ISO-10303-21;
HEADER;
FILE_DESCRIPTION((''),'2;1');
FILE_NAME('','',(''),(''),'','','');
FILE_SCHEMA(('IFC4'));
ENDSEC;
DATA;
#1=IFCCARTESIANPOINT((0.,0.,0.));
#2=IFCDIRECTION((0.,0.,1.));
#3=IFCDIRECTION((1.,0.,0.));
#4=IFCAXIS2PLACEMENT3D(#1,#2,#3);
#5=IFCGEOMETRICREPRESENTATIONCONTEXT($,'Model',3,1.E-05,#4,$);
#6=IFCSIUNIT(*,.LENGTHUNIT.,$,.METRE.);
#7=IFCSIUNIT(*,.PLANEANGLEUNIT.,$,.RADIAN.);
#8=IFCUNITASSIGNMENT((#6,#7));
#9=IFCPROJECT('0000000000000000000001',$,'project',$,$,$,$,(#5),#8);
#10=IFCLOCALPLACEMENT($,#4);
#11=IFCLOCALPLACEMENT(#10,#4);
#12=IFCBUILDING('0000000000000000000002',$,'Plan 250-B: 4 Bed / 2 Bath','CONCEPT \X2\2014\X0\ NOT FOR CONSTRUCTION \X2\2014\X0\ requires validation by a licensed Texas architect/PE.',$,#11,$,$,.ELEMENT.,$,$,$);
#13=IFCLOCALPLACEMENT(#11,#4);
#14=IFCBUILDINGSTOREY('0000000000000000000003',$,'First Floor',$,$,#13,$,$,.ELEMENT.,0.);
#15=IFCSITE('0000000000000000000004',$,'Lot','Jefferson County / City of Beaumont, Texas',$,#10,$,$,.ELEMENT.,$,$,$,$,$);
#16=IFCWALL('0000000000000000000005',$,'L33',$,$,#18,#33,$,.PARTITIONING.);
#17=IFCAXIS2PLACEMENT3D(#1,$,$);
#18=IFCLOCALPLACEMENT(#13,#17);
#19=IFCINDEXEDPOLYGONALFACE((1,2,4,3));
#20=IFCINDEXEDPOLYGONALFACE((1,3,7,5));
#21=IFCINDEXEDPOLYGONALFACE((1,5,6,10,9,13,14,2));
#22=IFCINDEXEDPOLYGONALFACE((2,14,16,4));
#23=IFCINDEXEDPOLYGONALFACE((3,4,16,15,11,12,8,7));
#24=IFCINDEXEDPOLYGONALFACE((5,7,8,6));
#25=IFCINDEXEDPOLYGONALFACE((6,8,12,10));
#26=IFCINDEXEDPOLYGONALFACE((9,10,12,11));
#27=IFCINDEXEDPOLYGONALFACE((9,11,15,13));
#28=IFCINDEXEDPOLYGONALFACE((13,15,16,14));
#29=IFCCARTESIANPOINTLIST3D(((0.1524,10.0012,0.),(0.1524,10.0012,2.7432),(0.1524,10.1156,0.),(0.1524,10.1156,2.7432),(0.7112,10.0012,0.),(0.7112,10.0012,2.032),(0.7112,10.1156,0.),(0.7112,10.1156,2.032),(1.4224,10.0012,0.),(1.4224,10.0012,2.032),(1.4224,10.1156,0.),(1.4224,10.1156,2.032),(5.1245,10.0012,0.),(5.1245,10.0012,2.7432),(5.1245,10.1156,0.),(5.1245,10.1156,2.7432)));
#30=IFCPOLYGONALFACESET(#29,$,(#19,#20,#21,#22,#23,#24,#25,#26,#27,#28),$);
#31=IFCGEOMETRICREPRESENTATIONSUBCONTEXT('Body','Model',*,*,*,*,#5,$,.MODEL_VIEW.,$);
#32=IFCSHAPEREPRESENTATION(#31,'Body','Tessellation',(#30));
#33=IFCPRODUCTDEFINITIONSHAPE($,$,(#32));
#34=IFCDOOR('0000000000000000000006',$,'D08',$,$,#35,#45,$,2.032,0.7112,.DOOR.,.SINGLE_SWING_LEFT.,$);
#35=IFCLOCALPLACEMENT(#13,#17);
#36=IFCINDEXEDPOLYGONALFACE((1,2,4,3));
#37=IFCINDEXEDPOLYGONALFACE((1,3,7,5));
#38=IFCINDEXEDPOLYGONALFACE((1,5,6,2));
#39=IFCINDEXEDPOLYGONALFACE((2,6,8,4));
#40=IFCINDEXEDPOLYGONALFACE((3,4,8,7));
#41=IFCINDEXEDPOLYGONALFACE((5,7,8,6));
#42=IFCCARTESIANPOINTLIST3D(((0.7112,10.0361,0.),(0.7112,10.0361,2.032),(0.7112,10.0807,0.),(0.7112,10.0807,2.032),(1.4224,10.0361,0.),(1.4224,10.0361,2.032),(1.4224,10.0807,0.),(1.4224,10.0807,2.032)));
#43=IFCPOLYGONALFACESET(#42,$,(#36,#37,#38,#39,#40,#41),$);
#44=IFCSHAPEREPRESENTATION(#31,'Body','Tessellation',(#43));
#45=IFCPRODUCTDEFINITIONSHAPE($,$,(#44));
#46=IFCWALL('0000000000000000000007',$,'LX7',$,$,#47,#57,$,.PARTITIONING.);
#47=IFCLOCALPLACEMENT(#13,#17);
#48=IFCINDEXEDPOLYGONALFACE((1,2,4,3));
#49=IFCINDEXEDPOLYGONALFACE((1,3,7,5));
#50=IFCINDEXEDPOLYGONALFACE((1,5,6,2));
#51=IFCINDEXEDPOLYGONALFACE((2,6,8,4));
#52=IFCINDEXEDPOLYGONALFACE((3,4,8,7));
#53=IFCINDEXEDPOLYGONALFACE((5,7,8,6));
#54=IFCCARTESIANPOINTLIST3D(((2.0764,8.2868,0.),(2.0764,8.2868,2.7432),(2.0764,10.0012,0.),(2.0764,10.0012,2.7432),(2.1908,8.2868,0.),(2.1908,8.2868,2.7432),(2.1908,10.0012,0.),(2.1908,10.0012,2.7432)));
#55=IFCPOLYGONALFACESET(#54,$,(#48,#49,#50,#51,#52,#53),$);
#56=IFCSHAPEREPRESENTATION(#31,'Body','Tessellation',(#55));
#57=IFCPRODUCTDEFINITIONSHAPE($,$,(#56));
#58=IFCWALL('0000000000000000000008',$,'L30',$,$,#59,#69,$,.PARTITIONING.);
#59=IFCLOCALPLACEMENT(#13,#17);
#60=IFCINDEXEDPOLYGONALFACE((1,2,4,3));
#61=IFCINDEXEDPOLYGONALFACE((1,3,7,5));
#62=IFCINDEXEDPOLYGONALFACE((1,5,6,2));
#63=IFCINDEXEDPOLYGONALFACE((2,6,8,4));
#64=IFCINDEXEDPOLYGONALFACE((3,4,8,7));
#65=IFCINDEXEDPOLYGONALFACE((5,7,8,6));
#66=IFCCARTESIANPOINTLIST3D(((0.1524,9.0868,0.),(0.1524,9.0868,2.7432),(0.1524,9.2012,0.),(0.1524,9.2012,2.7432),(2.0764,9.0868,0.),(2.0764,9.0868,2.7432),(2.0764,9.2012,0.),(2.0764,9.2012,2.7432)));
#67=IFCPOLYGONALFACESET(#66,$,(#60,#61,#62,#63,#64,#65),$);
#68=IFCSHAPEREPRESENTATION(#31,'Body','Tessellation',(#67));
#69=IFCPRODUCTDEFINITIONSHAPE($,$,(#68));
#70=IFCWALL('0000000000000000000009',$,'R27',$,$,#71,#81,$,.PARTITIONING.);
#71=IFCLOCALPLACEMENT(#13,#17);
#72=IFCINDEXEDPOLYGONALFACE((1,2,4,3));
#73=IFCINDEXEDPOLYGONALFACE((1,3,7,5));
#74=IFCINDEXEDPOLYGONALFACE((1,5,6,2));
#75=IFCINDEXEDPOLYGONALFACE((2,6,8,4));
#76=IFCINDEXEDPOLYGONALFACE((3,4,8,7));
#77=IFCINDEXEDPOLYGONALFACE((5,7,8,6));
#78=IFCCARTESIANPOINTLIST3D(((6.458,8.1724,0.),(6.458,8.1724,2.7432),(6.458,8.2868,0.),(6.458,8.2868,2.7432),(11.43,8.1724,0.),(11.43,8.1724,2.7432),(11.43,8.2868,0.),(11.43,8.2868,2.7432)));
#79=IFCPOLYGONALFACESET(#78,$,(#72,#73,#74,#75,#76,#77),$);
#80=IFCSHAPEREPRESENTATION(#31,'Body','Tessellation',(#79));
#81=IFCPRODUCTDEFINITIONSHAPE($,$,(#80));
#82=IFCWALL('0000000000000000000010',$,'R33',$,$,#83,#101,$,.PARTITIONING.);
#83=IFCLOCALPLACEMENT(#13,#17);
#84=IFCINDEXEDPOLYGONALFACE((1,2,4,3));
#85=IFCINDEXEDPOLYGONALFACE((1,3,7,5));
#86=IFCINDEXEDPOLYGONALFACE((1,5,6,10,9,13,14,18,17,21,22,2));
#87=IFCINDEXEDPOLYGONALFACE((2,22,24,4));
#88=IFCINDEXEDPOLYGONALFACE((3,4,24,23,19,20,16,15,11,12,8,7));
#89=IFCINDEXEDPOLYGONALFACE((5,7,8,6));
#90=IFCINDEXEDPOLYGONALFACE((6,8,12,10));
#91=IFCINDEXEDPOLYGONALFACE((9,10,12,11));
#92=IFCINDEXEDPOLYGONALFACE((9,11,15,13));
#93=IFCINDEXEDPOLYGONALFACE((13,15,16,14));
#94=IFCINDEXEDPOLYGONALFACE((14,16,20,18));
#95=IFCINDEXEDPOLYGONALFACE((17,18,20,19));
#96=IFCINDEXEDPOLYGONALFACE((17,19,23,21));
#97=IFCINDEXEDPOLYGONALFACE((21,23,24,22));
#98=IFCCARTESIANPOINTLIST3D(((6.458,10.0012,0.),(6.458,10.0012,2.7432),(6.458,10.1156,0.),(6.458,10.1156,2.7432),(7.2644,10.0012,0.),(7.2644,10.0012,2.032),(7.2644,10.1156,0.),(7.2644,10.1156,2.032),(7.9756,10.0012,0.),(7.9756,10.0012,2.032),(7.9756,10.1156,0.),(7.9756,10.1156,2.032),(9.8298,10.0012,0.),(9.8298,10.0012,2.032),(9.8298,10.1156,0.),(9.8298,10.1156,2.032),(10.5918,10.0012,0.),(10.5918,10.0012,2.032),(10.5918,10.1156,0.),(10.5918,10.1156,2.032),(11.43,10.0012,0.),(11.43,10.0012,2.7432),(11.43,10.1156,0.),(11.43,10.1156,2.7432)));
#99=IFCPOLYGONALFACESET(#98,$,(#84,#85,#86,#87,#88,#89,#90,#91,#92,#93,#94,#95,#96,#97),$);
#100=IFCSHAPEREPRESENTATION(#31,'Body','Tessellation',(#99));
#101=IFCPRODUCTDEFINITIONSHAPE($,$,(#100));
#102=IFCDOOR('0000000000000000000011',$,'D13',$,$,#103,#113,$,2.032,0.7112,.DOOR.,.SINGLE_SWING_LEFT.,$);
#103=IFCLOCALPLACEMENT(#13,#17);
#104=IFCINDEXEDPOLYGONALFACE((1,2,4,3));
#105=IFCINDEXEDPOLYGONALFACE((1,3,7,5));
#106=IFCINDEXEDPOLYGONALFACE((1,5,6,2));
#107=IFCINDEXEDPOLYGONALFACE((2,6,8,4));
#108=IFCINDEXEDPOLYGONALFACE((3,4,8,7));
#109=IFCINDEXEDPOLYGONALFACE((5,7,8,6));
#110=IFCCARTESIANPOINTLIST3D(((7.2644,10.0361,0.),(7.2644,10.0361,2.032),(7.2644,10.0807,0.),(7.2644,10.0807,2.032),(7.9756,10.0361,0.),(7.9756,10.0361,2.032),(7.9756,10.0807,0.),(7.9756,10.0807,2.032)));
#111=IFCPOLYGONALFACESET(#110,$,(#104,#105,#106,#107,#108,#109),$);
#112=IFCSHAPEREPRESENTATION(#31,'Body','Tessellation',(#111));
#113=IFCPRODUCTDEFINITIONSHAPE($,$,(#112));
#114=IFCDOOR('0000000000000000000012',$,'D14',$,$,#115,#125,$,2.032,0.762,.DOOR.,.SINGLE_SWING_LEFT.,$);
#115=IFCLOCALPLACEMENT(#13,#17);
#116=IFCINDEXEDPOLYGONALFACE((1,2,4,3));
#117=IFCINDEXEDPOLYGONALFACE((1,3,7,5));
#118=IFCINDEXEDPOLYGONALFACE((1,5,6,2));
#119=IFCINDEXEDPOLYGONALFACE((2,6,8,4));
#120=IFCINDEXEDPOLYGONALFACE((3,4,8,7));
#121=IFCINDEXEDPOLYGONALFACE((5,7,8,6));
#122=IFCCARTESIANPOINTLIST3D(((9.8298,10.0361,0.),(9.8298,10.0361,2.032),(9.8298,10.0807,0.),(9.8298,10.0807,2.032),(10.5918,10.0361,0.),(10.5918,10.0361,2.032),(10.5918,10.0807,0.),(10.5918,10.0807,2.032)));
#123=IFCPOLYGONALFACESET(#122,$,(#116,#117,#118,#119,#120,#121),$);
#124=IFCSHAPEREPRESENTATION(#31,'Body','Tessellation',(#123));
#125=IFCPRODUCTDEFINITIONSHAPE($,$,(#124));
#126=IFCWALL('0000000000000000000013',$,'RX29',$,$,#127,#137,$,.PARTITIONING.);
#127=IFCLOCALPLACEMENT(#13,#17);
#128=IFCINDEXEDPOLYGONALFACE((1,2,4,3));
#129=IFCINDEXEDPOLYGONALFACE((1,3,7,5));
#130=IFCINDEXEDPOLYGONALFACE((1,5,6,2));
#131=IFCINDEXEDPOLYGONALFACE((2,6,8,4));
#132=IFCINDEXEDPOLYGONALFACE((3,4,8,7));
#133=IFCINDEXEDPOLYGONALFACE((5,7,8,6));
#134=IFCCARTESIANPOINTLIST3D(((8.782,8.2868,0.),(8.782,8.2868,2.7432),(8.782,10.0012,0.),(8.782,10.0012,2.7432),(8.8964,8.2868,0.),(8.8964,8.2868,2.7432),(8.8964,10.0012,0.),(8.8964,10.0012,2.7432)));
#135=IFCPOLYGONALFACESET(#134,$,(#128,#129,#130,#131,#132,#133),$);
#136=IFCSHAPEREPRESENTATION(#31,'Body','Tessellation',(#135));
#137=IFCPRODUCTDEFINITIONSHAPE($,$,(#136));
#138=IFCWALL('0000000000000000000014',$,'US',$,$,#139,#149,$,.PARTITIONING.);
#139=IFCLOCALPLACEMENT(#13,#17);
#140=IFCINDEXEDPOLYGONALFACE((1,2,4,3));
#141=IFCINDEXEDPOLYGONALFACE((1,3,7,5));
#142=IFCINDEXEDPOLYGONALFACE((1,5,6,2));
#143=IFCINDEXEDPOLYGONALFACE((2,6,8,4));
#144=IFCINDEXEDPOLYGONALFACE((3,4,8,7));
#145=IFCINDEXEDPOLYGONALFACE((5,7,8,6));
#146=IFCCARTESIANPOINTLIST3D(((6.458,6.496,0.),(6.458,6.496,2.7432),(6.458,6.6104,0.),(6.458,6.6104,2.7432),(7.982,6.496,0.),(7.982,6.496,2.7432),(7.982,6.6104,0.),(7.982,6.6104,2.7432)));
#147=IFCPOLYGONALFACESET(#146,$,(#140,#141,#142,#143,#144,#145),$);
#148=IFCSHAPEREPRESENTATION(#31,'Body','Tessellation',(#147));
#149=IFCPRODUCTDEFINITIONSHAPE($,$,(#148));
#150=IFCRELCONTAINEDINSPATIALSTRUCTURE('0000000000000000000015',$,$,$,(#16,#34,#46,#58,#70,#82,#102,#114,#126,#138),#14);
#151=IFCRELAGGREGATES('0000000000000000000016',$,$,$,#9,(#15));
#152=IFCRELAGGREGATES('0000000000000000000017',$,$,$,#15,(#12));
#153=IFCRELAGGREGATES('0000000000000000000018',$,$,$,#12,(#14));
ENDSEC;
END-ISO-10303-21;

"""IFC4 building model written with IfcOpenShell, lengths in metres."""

from ifc_helpers import new_model, si_unit, frame, frame_2d, origin_with_axes, place, context, subcontext, project, spatial, rectangle, extrude, element, fill, save


model = new_model("IFC4")

# Units and contexts
model_context = context("Model", 3, precision=1e-05, world=origin_with_axes())
body_context = subcontext(model_context, "Body", "Model", "MODEL_VIEW")
ifc_project = project(units=[si_unit("LENGTHUNIT", "METRE"), si_unit("PLANEANGLEUNIT", "RADIAN")], contexts=[model_context])

# Site, building, storey
site_placement = place(None, origin_with_axes())
site = spatial("IfcSite", under=ifc_project, at=site_placement, Name="Lot", Description="Jefferson County / City of Beaumont, Texas", CompositionType="ELEMENT")
building_placement = place(site_placement, origin_with_axes())
building = spatial("IfcBuilding", under=site, at=building_placement, Name="Plan 250-B: 4 Bed / 2 Bath", Description="CONCEPT — NOT FOR CONSTRUCTION — requires validation by a licensed Texas architect/PE.", CompositionType="ELEMENT")
storey_placement = place(building_placement, origin_with_axes())
storey = spatial("IfcBuildingStorey", under=building, at=storey_placement, Name="First Floor", CompositionType="ELEMENT", Elevation=0.0)

# Wall, opening, door
wall_1_placement = place(storey_placement, frame((0.1524, 10.0584, 0.0), z_axis=(0.0, 0.0, 1.0), x_axis=(1.0, 0.0, 0.0)))
wall_1 = element("IfcWall", 1, at=wall_1_placement, inside=storey, Name="L33", PredefinedType="PARTITIONING", context=body_context, shape_type="SweptSolid", body=[
    extrude(rectangle(XDim=4.9721, YDim=0.1143, at=frame_2d((2.486, 0.0), x_axis=(1.0, 0.0))), origin_with_axes(), (0.0, 0.0, 1.0), 2.7432),
])
opening_1_placement = place(wall_1_placement, frame((0.5588, 0.0, 0.0), z_axis=(0.0, 0.0, 1.0), x_axis=(1.0, 0.0, 0.0)))
opening_1 = element("IfcOpeningElement", 2, at=opening_1_placement, cuts=wall_1, PredefinedType="OPENING", context=body_context, shape_type="SweptSolid", body=[
    extrude(rectangle(XDim=0.7112, YDim=0.1448, at=frame_2d((0.3556, 0.0), x_axis=(1.0, 0.0))), origin_with_axes(), (0.0, 0.0, 1.0), 2.032),
])
door_1_placement = place(opening_1_placement, origin_with_axes())
door_1 = element("IfcDoor", 3, at=door_1_placement, inside=storey, Name="D08", OperationType="SINGLE_SWING_LEFT", OverallHeight=2.032, OverallWidth=0.7112, PredefinedType="DOOR", context=body_context, shape_type="SweptSolid", body=[
    extrude(rectangle(XDim=0.7112, YDim=0.0445, at=frame_2d((0.3556, 0.0), x_axis=(1.0, 0.0))), origin_with_axes(), (0.0, 0.0, 1.0), 2.032),
])
fill(opening_1, door_1)

# Walls
wall_2_placement = place(storey_placement, frame((2.1336, 8.2867, 0.0), z_axis=(0.0, 0.0, 1.0), x_axis=(0.0, 1.0, 0.0)))
element("IfcWall", 4, at=wall_2_placement, inside=storey, Name="LX7", PredefinedType="PARTITIONING", context=body_context, shape_type="SweptSolid", body=[
    extrude(rectangle(XDim=1.7145, YDim=0.1143, at=frame_2d((0.8573, 0.0), x_axis=(1.0, 0.0))), origin_with_axes(), (0.0, 0.0, 1.0), 2.7432),
])
wall_3_placement = place(storey_placement, frame((0.1524, 9.144, 0.0), z_axis=(0.0, 0.0, 1.0), x_axis=(1.0, 0.0, 0.0)))
element("IfcWall", 5, at=wall_3_placement, inside=storey, Name="L30", PredefinedType="PARTITIONING", context=body_context, shape_type="SweptSolid", body=[
    extrude(rectangle(XDim=1.9241, YDim=0.1143, at=frame_2d((0.962, 0.0), x_axis=(1.0, 0.0))), origin_with_axes(), (0.0, 0.0, 1.0), 2.7432),
])
wall_4_placement = place(storey_placement, frame((6.458, 8.2296, 0.0), z_axis=(0.0, 0.0, 1.0), x_axis=(1.0, 0.0, 0.0)))
element("IfcWall", 6, at=wall_4_placement, inside=storey, Name="R27", PredefinedType="PARTITIONING", context=body_context, shape_type="SweptSolid", body=[
    extrude(rectangle(XDim=4.9721, YDim=0.1143, at=frame_2d((2.486, 0.0), x_axis=(1.0, 0.0))), origin_with_axes(), (0.0, 0.0, 1.0), 2.7432),
])

# Wall, openings, doors
wall_5_placement = place(storey_placement, frame((6.458, 10.0584, 0.0), z_axis=(0.0, 0.0, 1.0), x_axis=(1.0, 0.0, 0.0)))
wall_5 = element("IfcWall", 7, at=wall_5_placement, inside=storey, Name="R33", PredefinedType="PARTITIONING", context=body_context, shape_type="SweptSolid", body=[
    extrude(rectangle(XDim=4.9721, YDim=0.1143, at=frame_2d((2.486, 0.0), x_axis=(1.0, 0.0))), origin_with_axes(), (0.0, 0.0, 1.0), 2.7432),
])
opening_2_placement = place(wall_5_placement, frame((0.8065, 0.0, 0.0), z_axis=(0.0, 0.0, 1.0), x_axis=(1.0, 0.0, 0.0)))
opening_2 = element("IfcOpeningElement", 8, at=opening_2_placement, cuts=wall_5, PredefinedType="OPENING", context=body_context, shape_type="SweptSolid", body=[
    extrude(rectangle(XDim=0.7112, YDim=0.1448, at=frame_2d((0.3556, 0.0), x_axis=(1.0, 0.0))), origin_with_axes(), (0.0, 0.0, 1.0), 2.032),
])
opening_3_placement = place(wall_5_placement, frame((3.3719, 0.0, 0.0), z_axis=(0.0, 0.0, 1.0), x_axis=(1.0, 0.0, 0.0)))
opening_3 = element("IfcOpeningElement", 9, at=opening_3_placement, cuts=wall_5, PredefinedType="OPENING", context=body_context, shape_type="SweptSolid", body=[
    extrude(rectangle(XDim=0.762, YDim=0.1448, at=frame_2d((0.381, 0.0), x_axis=(1.0, 0.0))), origin_with_axes(), (0.0, 0.0, 1.0), 2.032),
])
door_2_placement = place(opening_2_placement, origin_with_axes())
door_2 = element("IfcDoor", 10, at=door_2_placement, inside=storey, Name="D13", OperationType="SINGLE_SWING_LEFT", OverallHeight=2.032, OverallWidth=0.7112, PredefinedType="DOOR", context=body_context, shape_type="SweptSolid", body=[
    extrude(rectangle(XDim=0.7112, YDim=0.0445, at=frame_2d((0.3556, 0.0), x_axis=(1.0, 0.0))), origin_with_axes(), (0.0, 0.0, 1.0), 2.032),
])
fill(opening_2, door_2)
door_3_placement = place(opening_3_placement, origin_with_axes())
door_3 = element("IfcDoor", 11, at=door_3_placement, inside=storey, Name="D14", OperationType="SINGLE_SWING_LEFT", OverallHeight=2.032, OverallWidth=0.762, PredefinedType="DOOR", context=body_context, shape_type="SweptSolid", body=[
    extrude(rectangle(XDim=0.762, YDim=0.0445, at=frame_2d((0.381, 0.0), x_axis=(1.0, 0.0))), origin_with_axes(), (0.0, 0.0, 1.0), 2.032),
])
fill(opening_3, door_3)

# Walls
wall_6_placement = place(storey_placement, frame((8.8392, 8.2867, 0.0), z_axis=(0.0, 0.0, 1.0), x_axis=(0.0, 1.0, 0.0)))
element("IfcWall", 12, at=wall_6_placement, inside=storey, Name="RX29", PredefinedType="PARTITIONING", context=body_context, shape_type="SweptSolid", body=[
    extrude(rectangle(XDim=1.7145, YDim=0.1143, at=frame_2d((0.8573, 0.0), x_axis=(1.0, 0.0))), origin_with_axes(), (0.0, 0.0, 1.0), 2.7432),
])
wall_7_placement = place(storey_placement, frame((6.458, 6.5532, 0.0), z_axis=(0.0, 0.0, 1.0), x_axis=(1.0, 0.0, 0.0)))
element("IfcWall", 13, at=wall_7_placement, inside=storey, Name="US", PredefinedType="PARTITIONING", context=body_context, shape_type="SweptSolid", body=[
    extrude(rectangle(XDim=1.524, YDim=0.1143, at=frame_2d((0.762, 0.0), x_axis=(1.0, 0.0))), origin_with_axes(), (0.0, 0.0, 1.0), 2.7432),
])

save(model, "model.ifc")
